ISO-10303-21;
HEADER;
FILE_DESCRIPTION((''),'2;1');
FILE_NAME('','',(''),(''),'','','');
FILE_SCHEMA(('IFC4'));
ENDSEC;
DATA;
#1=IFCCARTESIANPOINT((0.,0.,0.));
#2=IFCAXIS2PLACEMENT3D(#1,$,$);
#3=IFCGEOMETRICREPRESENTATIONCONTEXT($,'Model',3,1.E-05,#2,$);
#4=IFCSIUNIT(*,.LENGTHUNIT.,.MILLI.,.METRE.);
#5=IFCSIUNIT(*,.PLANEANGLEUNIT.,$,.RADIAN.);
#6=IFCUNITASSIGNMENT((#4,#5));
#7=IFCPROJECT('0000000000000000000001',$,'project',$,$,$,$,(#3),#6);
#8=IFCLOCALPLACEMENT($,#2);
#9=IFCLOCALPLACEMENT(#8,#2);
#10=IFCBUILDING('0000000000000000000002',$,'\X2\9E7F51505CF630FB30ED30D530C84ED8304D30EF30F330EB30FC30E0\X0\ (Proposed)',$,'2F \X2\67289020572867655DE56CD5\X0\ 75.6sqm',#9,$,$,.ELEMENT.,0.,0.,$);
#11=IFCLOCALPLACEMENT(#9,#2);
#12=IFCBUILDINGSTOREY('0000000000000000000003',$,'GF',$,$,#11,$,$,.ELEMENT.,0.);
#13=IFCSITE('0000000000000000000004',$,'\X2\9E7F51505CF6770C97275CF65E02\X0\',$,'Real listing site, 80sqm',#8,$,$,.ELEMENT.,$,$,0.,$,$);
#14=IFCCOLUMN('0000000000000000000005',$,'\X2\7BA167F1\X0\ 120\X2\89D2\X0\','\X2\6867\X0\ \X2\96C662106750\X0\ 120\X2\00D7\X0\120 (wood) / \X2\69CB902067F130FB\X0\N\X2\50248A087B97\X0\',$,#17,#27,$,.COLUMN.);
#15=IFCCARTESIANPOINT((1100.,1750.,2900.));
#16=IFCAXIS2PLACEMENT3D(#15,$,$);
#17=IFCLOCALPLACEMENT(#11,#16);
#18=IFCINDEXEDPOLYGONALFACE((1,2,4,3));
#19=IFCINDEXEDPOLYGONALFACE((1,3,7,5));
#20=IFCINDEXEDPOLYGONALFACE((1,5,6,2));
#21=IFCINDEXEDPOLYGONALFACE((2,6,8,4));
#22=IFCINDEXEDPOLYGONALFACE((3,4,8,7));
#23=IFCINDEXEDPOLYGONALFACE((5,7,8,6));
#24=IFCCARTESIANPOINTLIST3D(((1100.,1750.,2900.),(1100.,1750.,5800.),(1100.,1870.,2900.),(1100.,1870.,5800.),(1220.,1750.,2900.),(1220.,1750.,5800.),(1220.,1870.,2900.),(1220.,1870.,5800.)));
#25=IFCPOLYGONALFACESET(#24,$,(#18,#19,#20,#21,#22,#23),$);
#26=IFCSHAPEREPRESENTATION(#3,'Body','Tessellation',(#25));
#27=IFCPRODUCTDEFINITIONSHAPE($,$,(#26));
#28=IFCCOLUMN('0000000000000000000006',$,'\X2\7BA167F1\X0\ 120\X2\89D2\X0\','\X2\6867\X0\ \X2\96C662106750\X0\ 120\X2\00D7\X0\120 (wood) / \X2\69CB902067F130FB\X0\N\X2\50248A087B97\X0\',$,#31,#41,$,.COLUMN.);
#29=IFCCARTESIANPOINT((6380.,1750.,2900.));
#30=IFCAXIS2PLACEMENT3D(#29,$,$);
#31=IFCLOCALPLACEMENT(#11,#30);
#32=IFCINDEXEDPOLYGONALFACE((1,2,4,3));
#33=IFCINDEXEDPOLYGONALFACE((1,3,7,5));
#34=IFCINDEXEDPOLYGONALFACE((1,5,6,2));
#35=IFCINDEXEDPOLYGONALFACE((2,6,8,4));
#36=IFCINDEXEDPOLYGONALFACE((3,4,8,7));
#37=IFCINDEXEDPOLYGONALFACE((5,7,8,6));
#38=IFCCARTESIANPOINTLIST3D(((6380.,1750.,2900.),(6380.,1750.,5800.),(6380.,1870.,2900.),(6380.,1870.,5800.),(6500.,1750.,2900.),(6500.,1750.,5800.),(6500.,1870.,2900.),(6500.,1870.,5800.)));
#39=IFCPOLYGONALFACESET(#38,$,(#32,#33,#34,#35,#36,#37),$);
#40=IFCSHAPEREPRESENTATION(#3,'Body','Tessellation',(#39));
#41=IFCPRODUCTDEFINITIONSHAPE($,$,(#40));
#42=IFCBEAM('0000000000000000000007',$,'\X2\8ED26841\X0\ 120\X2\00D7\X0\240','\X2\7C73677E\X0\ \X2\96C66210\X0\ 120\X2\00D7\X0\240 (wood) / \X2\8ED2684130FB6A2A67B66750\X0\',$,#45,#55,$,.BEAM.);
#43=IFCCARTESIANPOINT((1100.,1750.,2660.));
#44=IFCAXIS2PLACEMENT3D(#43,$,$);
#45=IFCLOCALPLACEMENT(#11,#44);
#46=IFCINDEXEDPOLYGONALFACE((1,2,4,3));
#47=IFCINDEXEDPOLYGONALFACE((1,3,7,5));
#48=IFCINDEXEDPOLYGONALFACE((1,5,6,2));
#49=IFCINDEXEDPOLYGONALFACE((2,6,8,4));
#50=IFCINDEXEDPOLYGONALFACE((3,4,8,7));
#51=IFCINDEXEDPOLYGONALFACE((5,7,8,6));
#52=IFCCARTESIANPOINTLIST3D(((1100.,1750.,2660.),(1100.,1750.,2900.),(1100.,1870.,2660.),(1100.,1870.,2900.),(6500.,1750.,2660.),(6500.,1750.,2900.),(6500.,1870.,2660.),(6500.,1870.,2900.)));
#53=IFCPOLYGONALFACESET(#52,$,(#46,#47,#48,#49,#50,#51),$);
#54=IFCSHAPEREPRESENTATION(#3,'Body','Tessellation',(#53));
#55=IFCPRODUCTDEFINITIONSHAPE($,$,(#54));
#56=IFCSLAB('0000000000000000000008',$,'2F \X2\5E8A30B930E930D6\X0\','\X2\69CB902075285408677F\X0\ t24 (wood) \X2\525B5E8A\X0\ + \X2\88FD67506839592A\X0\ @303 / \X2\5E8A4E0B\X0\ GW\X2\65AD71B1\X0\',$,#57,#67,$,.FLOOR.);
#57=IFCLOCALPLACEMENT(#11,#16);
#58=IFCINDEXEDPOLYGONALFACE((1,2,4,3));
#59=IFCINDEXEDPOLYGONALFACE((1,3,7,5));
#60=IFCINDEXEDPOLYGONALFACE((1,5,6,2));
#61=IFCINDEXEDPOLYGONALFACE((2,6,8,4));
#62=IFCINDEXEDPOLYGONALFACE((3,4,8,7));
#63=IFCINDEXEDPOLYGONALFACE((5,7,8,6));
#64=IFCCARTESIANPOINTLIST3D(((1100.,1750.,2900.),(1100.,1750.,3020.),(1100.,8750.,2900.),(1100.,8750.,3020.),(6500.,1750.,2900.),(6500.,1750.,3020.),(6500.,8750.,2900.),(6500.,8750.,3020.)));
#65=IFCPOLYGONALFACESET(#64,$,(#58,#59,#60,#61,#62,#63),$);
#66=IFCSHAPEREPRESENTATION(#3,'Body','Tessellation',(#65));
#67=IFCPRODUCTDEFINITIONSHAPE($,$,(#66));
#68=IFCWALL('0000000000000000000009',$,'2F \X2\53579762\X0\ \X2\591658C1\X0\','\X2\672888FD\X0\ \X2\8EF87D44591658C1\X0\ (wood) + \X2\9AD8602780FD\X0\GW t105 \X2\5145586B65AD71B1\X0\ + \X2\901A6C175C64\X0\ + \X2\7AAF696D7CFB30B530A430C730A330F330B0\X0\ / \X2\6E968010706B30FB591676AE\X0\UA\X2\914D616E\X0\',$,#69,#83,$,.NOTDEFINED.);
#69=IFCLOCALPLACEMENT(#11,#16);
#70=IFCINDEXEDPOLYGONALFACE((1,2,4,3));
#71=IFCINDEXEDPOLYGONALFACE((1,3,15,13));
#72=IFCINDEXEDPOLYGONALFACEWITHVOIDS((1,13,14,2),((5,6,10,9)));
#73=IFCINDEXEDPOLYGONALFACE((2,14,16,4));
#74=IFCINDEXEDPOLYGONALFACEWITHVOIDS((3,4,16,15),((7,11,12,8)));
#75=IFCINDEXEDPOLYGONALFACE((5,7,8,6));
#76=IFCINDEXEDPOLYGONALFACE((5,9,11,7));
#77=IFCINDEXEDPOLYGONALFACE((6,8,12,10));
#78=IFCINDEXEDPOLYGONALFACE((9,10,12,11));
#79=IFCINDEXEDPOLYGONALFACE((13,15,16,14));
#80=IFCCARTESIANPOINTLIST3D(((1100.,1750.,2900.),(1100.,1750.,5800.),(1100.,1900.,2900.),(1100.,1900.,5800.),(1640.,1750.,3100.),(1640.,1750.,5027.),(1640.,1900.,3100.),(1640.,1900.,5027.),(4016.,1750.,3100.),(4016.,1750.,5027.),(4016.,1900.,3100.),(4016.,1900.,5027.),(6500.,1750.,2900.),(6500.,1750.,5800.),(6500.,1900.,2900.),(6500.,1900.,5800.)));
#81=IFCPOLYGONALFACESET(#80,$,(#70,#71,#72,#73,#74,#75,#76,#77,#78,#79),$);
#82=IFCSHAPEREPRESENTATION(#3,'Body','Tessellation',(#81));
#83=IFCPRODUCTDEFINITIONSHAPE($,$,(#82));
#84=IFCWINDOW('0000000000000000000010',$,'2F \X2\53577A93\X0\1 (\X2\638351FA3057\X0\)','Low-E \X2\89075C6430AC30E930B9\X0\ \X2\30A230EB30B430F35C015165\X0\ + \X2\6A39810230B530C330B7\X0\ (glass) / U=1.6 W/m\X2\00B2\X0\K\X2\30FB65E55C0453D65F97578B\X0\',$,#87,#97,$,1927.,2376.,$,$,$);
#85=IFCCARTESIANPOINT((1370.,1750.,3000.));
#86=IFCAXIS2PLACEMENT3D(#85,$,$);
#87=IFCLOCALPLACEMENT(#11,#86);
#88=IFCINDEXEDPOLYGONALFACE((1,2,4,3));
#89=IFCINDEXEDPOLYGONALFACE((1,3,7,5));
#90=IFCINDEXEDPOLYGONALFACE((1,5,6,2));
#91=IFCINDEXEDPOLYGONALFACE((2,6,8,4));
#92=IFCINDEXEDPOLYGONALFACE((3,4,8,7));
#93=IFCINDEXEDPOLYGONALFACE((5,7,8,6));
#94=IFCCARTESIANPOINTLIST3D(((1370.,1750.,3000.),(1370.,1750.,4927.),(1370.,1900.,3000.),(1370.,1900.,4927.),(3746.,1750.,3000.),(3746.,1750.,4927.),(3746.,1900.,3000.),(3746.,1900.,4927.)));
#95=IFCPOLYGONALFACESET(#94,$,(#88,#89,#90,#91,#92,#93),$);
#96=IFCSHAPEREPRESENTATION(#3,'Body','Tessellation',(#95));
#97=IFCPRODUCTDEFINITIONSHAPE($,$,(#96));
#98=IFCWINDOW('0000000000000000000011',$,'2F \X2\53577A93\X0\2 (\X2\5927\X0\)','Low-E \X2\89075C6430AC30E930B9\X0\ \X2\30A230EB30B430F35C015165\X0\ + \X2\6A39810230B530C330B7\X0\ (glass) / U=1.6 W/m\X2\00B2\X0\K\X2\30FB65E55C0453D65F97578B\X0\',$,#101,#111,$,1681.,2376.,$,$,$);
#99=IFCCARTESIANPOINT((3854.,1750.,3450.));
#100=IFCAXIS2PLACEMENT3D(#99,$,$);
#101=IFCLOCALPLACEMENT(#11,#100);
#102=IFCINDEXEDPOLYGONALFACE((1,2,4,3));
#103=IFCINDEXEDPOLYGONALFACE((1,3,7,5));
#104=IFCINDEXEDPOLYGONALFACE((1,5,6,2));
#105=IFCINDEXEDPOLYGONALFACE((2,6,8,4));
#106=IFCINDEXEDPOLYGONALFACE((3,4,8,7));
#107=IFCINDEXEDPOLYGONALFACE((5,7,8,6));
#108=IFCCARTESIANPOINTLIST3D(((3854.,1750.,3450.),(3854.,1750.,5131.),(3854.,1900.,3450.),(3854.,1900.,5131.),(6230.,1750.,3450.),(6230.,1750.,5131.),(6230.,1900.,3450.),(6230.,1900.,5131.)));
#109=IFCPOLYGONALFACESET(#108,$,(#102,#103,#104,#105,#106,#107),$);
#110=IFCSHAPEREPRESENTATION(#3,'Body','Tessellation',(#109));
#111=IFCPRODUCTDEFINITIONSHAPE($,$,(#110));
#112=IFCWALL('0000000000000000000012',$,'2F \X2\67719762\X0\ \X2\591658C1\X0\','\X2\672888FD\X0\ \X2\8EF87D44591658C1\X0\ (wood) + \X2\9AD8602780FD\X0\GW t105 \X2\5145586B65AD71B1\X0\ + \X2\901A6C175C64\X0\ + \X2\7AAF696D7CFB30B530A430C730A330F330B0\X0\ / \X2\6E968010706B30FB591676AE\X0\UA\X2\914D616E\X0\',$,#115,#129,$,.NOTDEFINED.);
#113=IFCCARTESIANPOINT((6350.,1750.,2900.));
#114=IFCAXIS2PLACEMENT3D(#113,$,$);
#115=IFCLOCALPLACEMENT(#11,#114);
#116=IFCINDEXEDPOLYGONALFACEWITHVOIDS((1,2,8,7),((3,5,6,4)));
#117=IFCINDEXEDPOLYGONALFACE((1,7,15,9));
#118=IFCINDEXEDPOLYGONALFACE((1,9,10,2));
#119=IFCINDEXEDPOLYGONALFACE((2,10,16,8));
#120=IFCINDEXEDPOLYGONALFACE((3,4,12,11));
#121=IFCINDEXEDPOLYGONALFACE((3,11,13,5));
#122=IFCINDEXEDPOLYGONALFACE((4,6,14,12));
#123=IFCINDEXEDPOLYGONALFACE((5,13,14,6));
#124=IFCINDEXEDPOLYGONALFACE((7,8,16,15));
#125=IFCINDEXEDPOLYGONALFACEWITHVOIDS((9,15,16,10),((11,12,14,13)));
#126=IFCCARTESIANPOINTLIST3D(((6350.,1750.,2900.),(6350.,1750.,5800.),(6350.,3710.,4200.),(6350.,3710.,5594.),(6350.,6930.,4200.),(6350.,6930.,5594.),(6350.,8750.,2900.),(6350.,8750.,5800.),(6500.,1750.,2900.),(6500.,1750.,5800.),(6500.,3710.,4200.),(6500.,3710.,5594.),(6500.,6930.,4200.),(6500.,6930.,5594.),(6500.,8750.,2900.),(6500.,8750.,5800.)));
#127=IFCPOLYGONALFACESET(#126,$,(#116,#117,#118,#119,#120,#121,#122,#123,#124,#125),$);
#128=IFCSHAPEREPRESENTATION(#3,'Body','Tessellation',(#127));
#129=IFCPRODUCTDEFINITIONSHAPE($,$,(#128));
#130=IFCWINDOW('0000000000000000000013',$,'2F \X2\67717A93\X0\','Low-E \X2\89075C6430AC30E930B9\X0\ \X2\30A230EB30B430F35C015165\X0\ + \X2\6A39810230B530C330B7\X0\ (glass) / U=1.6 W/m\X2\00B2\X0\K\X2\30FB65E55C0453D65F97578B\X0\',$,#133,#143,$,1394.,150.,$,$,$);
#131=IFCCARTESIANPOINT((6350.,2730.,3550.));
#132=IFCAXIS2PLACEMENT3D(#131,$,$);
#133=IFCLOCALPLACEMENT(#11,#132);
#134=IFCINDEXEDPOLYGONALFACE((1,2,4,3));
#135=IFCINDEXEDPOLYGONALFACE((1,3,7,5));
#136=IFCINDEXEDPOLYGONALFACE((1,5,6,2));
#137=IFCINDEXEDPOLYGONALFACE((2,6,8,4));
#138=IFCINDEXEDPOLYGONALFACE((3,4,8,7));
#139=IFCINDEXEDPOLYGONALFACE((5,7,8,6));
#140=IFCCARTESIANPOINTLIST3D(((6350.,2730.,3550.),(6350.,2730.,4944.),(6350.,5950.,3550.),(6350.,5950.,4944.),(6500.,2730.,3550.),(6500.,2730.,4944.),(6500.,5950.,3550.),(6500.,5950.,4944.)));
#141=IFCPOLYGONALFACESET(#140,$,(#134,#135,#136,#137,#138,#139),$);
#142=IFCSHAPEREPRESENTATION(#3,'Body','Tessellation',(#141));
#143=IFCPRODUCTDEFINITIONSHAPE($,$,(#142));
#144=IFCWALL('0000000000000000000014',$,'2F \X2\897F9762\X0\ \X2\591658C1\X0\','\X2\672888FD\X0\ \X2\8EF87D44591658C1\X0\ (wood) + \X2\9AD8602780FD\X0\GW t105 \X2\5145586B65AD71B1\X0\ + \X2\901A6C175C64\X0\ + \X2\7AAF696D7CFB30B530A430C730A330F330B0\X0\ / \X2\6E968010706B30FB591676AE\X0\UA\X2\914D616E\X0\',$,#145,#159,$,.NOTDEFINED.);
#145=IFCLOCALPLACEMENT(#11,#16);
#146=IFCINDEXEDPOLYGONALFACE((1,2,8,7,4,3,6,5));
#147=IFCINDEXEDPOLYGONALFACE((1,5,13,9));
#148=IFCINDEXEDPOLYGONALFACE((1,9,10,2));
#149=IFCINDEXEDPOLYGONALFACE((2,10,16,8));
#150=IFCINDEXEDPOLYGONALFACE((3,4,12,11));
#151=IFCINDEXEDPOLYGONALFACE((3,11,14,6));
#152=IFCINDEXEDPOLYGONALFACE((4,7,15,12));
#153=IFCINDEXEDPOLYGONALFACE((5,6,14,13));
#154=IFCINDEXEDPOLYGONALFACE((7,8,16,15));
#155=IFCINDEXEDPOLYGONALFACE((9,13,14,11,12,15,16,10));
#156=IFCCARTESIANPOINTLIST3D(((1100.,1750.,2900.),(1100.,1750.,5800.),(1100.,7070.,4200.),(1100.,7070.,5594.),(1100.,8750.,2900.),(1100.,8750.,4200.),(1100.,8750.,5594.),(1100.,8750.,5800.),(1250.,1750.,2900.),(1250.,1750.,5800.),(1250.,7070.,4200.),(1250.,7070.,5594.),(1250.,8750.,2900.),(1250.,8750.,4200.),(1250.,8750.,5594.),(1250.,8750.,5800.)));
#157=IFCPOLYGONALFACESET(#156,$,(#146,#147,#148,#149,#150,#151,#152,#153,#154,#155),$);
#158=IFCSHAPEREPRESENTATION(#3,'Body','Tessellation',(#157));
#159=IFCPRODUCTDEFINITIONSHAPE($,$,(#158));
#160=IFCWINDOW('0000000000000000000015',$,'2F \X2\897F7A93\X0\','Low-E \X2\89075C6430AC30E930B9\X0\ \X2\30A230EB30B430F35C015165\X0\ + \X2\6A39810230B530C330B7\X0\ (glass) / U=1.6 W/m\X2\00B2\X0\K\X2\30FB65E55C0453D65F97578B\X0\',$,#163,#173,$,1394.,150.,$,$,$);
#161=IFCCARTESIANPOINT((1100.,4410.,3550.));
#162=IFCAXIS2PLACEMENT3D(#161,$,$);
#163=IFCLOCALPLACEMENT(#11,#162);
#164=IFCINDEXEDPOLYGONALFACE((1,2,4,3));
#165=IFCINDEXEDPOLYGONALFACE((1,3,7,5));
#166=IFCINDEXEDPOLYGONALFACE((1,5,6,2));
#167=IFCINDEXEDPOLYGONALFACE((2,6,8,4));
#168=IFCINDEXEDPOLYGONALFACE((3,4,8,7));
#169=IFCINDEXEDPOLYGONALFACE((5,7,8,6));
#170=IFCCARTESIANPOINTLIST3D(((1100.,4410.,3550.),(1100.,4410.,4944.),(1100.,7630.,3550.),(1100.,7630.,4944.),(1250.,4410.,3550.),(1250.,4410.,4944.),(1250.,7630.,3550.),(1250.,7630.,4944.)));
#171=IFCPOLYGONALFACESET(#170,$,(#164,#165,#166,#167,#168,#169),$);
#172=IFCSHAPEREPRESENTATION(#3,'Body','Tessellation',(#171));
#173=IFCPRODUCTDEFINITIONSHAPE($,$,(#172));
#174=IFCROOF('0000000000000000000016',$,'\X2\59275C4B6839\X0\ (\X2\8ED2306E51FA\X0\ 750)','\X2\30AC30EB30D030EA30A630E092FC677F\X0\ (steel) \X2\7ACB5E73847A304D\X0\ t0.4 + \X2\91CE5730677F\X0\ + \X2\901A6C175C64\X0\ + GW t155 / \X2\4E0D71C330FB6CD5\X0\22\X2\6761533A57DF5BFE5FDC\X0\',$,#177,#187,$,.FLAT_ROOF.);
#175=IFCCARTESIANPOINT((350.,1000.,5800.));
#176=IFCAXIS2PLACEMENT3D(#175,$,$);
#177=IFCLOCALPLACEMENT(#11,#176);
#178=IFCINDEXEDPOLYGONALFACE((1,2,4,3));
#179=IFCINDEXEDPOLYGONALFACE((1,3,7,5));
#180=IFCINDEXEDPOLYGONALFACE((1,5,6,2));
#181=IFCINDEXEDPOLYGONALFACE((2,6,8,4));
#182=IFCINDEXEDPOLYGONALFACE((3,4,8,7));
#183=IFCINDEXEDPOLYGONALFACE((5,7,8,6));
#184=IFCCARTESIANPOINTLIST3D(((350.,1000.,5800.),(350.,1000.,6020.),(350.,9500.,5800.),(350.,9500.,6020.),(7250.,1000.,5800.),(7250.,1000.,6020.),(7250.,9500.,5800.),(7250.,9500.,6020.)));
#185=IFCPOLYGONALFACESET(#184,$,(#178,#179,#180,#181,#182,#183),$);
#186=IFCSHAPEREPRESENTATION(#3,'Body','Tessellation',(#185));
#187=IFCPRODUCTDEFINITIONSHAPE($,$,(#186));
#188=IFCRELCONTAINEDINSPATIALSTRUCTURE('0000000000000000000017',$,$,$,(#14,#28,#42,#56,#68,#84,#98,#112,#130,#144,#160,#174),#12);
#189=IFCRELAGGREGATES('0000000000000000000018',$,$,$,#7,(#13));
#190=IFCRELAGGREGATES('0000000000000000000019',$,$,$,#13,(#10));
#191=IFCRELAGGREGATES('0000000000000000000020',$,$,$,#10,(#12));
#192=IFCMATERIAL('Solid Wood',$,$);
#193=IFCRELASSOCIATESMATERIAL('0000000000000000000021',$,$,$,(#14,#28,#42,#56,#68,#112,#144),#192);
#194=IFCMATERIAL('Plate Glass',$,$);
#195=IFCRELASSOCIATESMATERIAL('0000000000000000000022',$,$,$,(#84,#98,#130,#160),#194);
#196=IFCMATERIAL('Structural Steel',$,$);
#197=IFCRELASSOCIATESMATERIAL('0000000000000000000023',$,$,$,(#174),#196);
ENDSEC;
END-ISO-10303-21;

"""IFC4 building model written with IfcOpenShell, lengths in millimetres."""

from ifc_helpers import new_model, si_unit, frame, frame_2d, origin, place, context, project, spatial, rectangle, extrude, material, element, fill, save


model = new_model("IFC4")

# Units and contexts
model_context = context("Model", 3, precision=1e-05, world=origin())
ifc_project = project(units=[si_unit("LENGTHUNIT", "METRE", prefix="MILLI"), si_unit("PLANEANGLEUNIT", "RADIAN")], contexts=[model_context])

# Site, building, storey
site_placement = place(None, origin())
site = spatial("IfcSite", under=ifc_project, at=site_placement, Name="鹿児島県霧島市", ObjectType="Real listing site, 80sqm", CompositionType="ELEMENT", RefElevation=0.0)
building_placement = place(site_placement, origin())
building = spatial("IfcBuilding", under=site, at=building_placement, Name="鹿児島・ロフト付きワンルーム (Proposed)", ObjectType="2F 木造在来工法 75.6sqm", CompositionType="ELEMENT", ElevationOfRefHeight=0.0, ElevationOfTerrain=0.0)
storey_placement = place(building_placement, origin())
storey = spatial("IfcBuildingStorey", under=building, at=storey_placement, Name="GF", CompositionType="ELEMENT", Elevation=0.0)

# Columns
ifc_material_1 = material(Name="Solid Wood")
column_1_placement = place(storey_placement, frame((1100.0, 1750.0, 2900.0)))
element("IfcColumn", 1, at=column_1_placement, inside=storey, material=ifc_material_1, Name="管柱 120角", Description="桧 集成材 120×120 (wood) / 構造柱・N値計算", PredefinedType="COLUMN", context=model_context, shape_type="SweptSolid", body=[
    extrude(rectangle(XDim=120.0, YDim=120.0, at=frame_2d((60.0, 60.0))), frame((1100.0, 1750.0, 2900.0)), (0.0, 0.0, 1.0), 2900.0),
])
column_2_placement = place(storey_placement, frame((6380.0, 1750.0, 2900.0)))
element("IfcColumn", 2, at=column_2_placement, inside=storey, material=ifc_material_1, Name="管柱 120角", Description="桧 集成材 120×120 (wood) / 構造柱・N値計算", PredefinedType="COLUMN", context=model_context, shape_type="SweptSolid", body=[
    extrude(rectangle(XDim=120.0, YDim=120.0, at=frame_2d((60.0, 60.0))), frame((6380.0, 1750.0, 2900.0)), (0.0, 0.0, 1.0), 2900.0),
])

# Beam
beam_1_placement = place(storey_placement, frame((1100.0, 1750.0, 2660.0)))
element("IfcBeam", 3, at=beam_1_placement, inside=storey, material=ifc_material_1, Name="軒桁 120×240", Description="米松 集成 120×240 (wood) / 軒桁・横架材", PredefinedType="BEAM", context=model_context, shape_type="SweptSolid", body=[
    extrude(rectangle(XDim=5400.0, YDim=120.0, at=frame_2d((2700.0, 60.0))), frame((1100.0, 1750.0, 2660.0)), (0.0, 0.0, 1.0), 240.0),
])

# Slab
slab_placement = place(storey_placement, frame((1100.0, 1750.0, 2900.0)))
element("IfcSlab", 4, at=slab_placement, inside=storey, material=ifc_material_1, Name="2F 床スラブ", Description="構造用合板 t24 (wood) 剛床 + 製材根太 @303 / 床下 GW断熱", PredefinedType="FLOOR", context=model_context, shape_type="SweptSolid", body=[
    extrude(rectangle(XDim=5400.0, YDim=7000.0, at=frame_2d((2700.0, 3500.0))), frame((1100.0, 1750.0, 2900.0)), (0.0, 0.0, 1.0), 120.0),
])

# Wall, openings, windows
wall_1_placement = place(storey_placement, frame((1100.0, 1750.0, 2900.0)))
wall_1 = element("IfcWall", 5, at=wall_1_placement, inside=storey, material=ifc_material_1, Name="2F 南面 外壁", Description="木製 軸組外壁 (wood) + 高性能GW t105 充填断熱 + 通気層 + 窯業系サイディング / 準耐火・外皮UA配慮", PredefinedType="NOTDEFINED", context=model_context, shape_type="SweptSolid", body=[
    extrude(rectangle(XDim=5400.0, YDim=150.0, at=frame_2d((2700.0, 75.0))), frame((1100.0, 1750.0, 2900.0)), (0.0, 0.0, 1.0), 2900.0),
])
opening_1_placement = place(storey_placement, frame((1370.0, 1750.0, 3000.0)))
opening_1 = element("IfcOpeningElement", 6, at=opening_1_placement, cuts=wall_1, PredefinedType="NOTDEFINED", context=model_context, shape_type="SweptSolid", body=[
    extrude(rectangle(XDim=2376.0, YDim=150.0, at=frame_2d((1188.0, 75.0))), frame((1370.0, 1750.0, 3000.0)), (0.0, 0.0, 1.0), 1927.0),
])
opening_2_placement = place(storey_placement, frame((3854.0, 1750.0, 3450.0)))
opening_2 = element("IfcOpeningElement", 7, at=opening_2_placement, cuts=wall_1, PredefinedType="NOTDEFINED", context=model_context, shape_type="SweptSolid", body=[
    extrude(rectangle(XDim=2376.0, YDim=150.0, at=frame_2d((1188.0, 75.0))), frame((3854.0, 1750.0, 3450.0)), (0.0, 0.0, 1.0), 1681.0),
])
ifc_material_2 = material(Name="Plate Glass")
window_1_placement = place(storey_placement, frame((1370.0, 1750.0, 3000.0)))
window_1 = element("IfcWindow", 8, at=window_1_placement, inside=storey, material=ifc_material_2, Name="2F 南窓1 (掃出し)", Description="Low-E 複層ガラス アルゴン封入 + 樹脂サッシ (glass) / U=1.6 W/m²K・日射取得型", OverallHeight=1927.0, OverallWidth=2376.0, context=model_context, shape_type="SweptSolid", body=[
    extrude(rectangle(XDim=2376.0, YDim=150.0, at=frame_2d((1188.0, 75.0))), frame((1370.0, 1750.0, 3000.0)), (0.0, 0.0, 1.0), 1927.0),
])
fill(opening_1, window_1)
window_2_placement = place(storey_placement, frame((3854.0, 1750.0, 3450.0)))
window_2 = element("IfcWindow", 9, at=window_2_placement, inside=storey, material=ifc_material_2, Name="2F 南窓2 (大)", Description="Low-E 複層ガラス アルゴン封入 + 樹脂サッシ (glass) / U=1.6 W/m²K・日射取得型", OverallHeight=1681.0, OverallWidth=2376.0, context=model_context, shape_type="SweptSolid", body=[
    extrude(rectangle(XDim=2376.0, YDim=150.0, at=frame_2d((1188.0, 75.0))), frame((3854.0, 1750.0, 3450.0)), (0.0, 0.0, 1.0), 1681.0),
])
fill(opening_2, window_2)

# Walls, openings, windows
wall_2_placement = place(storey_placement, frame((6350.0, 1750.0, 2900.0)))
wall_2 = element("IfcWall", 10, at=wall_2_placement, inside=storey, material=ifc_material_1, Name="2F 東面 外壁", Description="木製 軸組外壁 (wood) + 高性能GW t105 充填断熱 + 通気層 + 窯業系サイディング / 準耐火・外皮UA配慮", PredefinedType="NOTDEFINED", context=model_context, shape_type="SweptSolid", body=[
    extrude(rectangle(XDim=150.0, YDim=7000.0, at=frame_2d((75.0, 3500.0))), frame((6350.0, 1750.0, 2900.0)), (0.0, 0.0, 1.0), 2900.0),
])
opening_3_placement = place(storey_placement, frame((6350.0, 2730.0, 3550.0)))
opening_3 = element("IfcOpeningElement", 11, at=opening_3_placement, cuts=wall_2, PredefinedType="NOTDEFINED", context=model_context, shape_type="SweptSolid", body=[
    extrude(rectangle(XDim=150.0, YDim=3220.0, at=frame_2d((75.0, 1610.0))), frame((6350.0, 2730.0, 3550.0)), (0.0, 0.0, 1.0), 1394.0),
])
window_3_placement = place(storey_placement, frame((6350.0, 2730.0, 3550.0)))
window_3 = element("IfcWindow", 12, at=window_3_placement, inside=storey, material=ifc_material_2, Name="2F 東窓", Description="Low-E 複層ガラス アルゴン封入 + 樹脂サッシ (glass) / U=1.6 W/m²K・日射取得型", OverallHeight=1394.0, OverallWidth=150.0, context=model_context, shape_type="SweptSolid", body=[
    extrude(rectangle(XDim=150.0, YDim=3220.0, at=frame_2d((75.0, 1610.0))), frame((6350.0, 2730.0, 3550.0)), (0.0, 0.0, 1.0), 1394.0),
])
fill(opening_3, window_3)
wall_3_placement = place(storey_placement, frame((1100.0, 1750.0, 2900.0)))
wall_3 = element("IfcWall", 13, at=wall_3_placement, inside=storey, material=ifc_material_1, Name="2F 西面 外壁", Description="木製 軸組外壁 (wood) + 高性能GW t105 充填断熱 + 通気層 + 窯業系サイディング / 準耐火・外皮UA配慮", PredefinedType="NOTDEFINED", context=model_context, shape_type="SweptSolid", body=[
    extrude(rectangle(XDim=150.0, YDim=7000.0, at=frame_2d((75.0, 3500.0))), frame((1100.0, 1750.0, 2900.0)), (0.0, 0.0, 1.0), 2900.0),
])
opening_4_placement = place(storey_placement, frame((1100.0, 4410.0, 3550.0)))
opening_4 = element("IfcOpeningElement", 14, at=opening_4_placement, cuts=wall_3, PredefinedType="NOTDEFINED", context=model_context, shape_type="SweptSolid", body=[
    extrude(rectangle(XDim=150.0, YDim=3220.0, at=frame_2d((75.0, 1610.0))), frame((1100.0, 4410.0, 3550.0)), (0.0, 0.0, 1.0), 1394.0),
])
window_4_placement = place(storey_placement, frame((1100.0, 4410.0, 3550.0)))
window_4 = element("IfcWindow", 15, at=window_4_placement, inside=storey, material=ifc_material_2, Name="2F 西窓", Description="Low-E 複層ガラス アルゴン封入 + 樹脂サッシ (glass) / U=1.6 W/m²K・日射取得型", OverallHeight=1394.0, OverallWidth=150.0, context=model_context, shape_type="SweptSolid", body=[
    extrude(rectangle(XDim=150.0, YDim=3220.0, at=frame_2d((75.0, 1610.0))), frame((1100.0, 4410.0, 3550.0)), (0.0, 0.0, 1.0), 1394.0),
])
fill(opening_4, window_4)

# Roof
ifc_material_3 = material(Name="Structural Steel")
roof_placement = place(storey_placement, frame((350.0, 1000.0, 5800.0)))
element("IfcRoof", 16, at=roof_placement, inside=storey, material=ifc_material_3, Name="大屋根 (軒の出 750)", Description="ガルバリウム鋼板 (steel) 立平葺き t0.4 + 野地板 + 通気層 + GW t155 / 不燃・法22条区域対応", PredefinedType="FLAT_ROOF", context=model_context, shape_type="SweptSolid", body=[
    extrude(rectangle(XDim=6900.0, YDim=8500.0, at=frame_2d((3450.0, 4250.0))), frame((350.0, 1000.0, 5800.0)), (0.0, 0.0, 1.0), 220.0),
])

save(model, "model.ifc")
